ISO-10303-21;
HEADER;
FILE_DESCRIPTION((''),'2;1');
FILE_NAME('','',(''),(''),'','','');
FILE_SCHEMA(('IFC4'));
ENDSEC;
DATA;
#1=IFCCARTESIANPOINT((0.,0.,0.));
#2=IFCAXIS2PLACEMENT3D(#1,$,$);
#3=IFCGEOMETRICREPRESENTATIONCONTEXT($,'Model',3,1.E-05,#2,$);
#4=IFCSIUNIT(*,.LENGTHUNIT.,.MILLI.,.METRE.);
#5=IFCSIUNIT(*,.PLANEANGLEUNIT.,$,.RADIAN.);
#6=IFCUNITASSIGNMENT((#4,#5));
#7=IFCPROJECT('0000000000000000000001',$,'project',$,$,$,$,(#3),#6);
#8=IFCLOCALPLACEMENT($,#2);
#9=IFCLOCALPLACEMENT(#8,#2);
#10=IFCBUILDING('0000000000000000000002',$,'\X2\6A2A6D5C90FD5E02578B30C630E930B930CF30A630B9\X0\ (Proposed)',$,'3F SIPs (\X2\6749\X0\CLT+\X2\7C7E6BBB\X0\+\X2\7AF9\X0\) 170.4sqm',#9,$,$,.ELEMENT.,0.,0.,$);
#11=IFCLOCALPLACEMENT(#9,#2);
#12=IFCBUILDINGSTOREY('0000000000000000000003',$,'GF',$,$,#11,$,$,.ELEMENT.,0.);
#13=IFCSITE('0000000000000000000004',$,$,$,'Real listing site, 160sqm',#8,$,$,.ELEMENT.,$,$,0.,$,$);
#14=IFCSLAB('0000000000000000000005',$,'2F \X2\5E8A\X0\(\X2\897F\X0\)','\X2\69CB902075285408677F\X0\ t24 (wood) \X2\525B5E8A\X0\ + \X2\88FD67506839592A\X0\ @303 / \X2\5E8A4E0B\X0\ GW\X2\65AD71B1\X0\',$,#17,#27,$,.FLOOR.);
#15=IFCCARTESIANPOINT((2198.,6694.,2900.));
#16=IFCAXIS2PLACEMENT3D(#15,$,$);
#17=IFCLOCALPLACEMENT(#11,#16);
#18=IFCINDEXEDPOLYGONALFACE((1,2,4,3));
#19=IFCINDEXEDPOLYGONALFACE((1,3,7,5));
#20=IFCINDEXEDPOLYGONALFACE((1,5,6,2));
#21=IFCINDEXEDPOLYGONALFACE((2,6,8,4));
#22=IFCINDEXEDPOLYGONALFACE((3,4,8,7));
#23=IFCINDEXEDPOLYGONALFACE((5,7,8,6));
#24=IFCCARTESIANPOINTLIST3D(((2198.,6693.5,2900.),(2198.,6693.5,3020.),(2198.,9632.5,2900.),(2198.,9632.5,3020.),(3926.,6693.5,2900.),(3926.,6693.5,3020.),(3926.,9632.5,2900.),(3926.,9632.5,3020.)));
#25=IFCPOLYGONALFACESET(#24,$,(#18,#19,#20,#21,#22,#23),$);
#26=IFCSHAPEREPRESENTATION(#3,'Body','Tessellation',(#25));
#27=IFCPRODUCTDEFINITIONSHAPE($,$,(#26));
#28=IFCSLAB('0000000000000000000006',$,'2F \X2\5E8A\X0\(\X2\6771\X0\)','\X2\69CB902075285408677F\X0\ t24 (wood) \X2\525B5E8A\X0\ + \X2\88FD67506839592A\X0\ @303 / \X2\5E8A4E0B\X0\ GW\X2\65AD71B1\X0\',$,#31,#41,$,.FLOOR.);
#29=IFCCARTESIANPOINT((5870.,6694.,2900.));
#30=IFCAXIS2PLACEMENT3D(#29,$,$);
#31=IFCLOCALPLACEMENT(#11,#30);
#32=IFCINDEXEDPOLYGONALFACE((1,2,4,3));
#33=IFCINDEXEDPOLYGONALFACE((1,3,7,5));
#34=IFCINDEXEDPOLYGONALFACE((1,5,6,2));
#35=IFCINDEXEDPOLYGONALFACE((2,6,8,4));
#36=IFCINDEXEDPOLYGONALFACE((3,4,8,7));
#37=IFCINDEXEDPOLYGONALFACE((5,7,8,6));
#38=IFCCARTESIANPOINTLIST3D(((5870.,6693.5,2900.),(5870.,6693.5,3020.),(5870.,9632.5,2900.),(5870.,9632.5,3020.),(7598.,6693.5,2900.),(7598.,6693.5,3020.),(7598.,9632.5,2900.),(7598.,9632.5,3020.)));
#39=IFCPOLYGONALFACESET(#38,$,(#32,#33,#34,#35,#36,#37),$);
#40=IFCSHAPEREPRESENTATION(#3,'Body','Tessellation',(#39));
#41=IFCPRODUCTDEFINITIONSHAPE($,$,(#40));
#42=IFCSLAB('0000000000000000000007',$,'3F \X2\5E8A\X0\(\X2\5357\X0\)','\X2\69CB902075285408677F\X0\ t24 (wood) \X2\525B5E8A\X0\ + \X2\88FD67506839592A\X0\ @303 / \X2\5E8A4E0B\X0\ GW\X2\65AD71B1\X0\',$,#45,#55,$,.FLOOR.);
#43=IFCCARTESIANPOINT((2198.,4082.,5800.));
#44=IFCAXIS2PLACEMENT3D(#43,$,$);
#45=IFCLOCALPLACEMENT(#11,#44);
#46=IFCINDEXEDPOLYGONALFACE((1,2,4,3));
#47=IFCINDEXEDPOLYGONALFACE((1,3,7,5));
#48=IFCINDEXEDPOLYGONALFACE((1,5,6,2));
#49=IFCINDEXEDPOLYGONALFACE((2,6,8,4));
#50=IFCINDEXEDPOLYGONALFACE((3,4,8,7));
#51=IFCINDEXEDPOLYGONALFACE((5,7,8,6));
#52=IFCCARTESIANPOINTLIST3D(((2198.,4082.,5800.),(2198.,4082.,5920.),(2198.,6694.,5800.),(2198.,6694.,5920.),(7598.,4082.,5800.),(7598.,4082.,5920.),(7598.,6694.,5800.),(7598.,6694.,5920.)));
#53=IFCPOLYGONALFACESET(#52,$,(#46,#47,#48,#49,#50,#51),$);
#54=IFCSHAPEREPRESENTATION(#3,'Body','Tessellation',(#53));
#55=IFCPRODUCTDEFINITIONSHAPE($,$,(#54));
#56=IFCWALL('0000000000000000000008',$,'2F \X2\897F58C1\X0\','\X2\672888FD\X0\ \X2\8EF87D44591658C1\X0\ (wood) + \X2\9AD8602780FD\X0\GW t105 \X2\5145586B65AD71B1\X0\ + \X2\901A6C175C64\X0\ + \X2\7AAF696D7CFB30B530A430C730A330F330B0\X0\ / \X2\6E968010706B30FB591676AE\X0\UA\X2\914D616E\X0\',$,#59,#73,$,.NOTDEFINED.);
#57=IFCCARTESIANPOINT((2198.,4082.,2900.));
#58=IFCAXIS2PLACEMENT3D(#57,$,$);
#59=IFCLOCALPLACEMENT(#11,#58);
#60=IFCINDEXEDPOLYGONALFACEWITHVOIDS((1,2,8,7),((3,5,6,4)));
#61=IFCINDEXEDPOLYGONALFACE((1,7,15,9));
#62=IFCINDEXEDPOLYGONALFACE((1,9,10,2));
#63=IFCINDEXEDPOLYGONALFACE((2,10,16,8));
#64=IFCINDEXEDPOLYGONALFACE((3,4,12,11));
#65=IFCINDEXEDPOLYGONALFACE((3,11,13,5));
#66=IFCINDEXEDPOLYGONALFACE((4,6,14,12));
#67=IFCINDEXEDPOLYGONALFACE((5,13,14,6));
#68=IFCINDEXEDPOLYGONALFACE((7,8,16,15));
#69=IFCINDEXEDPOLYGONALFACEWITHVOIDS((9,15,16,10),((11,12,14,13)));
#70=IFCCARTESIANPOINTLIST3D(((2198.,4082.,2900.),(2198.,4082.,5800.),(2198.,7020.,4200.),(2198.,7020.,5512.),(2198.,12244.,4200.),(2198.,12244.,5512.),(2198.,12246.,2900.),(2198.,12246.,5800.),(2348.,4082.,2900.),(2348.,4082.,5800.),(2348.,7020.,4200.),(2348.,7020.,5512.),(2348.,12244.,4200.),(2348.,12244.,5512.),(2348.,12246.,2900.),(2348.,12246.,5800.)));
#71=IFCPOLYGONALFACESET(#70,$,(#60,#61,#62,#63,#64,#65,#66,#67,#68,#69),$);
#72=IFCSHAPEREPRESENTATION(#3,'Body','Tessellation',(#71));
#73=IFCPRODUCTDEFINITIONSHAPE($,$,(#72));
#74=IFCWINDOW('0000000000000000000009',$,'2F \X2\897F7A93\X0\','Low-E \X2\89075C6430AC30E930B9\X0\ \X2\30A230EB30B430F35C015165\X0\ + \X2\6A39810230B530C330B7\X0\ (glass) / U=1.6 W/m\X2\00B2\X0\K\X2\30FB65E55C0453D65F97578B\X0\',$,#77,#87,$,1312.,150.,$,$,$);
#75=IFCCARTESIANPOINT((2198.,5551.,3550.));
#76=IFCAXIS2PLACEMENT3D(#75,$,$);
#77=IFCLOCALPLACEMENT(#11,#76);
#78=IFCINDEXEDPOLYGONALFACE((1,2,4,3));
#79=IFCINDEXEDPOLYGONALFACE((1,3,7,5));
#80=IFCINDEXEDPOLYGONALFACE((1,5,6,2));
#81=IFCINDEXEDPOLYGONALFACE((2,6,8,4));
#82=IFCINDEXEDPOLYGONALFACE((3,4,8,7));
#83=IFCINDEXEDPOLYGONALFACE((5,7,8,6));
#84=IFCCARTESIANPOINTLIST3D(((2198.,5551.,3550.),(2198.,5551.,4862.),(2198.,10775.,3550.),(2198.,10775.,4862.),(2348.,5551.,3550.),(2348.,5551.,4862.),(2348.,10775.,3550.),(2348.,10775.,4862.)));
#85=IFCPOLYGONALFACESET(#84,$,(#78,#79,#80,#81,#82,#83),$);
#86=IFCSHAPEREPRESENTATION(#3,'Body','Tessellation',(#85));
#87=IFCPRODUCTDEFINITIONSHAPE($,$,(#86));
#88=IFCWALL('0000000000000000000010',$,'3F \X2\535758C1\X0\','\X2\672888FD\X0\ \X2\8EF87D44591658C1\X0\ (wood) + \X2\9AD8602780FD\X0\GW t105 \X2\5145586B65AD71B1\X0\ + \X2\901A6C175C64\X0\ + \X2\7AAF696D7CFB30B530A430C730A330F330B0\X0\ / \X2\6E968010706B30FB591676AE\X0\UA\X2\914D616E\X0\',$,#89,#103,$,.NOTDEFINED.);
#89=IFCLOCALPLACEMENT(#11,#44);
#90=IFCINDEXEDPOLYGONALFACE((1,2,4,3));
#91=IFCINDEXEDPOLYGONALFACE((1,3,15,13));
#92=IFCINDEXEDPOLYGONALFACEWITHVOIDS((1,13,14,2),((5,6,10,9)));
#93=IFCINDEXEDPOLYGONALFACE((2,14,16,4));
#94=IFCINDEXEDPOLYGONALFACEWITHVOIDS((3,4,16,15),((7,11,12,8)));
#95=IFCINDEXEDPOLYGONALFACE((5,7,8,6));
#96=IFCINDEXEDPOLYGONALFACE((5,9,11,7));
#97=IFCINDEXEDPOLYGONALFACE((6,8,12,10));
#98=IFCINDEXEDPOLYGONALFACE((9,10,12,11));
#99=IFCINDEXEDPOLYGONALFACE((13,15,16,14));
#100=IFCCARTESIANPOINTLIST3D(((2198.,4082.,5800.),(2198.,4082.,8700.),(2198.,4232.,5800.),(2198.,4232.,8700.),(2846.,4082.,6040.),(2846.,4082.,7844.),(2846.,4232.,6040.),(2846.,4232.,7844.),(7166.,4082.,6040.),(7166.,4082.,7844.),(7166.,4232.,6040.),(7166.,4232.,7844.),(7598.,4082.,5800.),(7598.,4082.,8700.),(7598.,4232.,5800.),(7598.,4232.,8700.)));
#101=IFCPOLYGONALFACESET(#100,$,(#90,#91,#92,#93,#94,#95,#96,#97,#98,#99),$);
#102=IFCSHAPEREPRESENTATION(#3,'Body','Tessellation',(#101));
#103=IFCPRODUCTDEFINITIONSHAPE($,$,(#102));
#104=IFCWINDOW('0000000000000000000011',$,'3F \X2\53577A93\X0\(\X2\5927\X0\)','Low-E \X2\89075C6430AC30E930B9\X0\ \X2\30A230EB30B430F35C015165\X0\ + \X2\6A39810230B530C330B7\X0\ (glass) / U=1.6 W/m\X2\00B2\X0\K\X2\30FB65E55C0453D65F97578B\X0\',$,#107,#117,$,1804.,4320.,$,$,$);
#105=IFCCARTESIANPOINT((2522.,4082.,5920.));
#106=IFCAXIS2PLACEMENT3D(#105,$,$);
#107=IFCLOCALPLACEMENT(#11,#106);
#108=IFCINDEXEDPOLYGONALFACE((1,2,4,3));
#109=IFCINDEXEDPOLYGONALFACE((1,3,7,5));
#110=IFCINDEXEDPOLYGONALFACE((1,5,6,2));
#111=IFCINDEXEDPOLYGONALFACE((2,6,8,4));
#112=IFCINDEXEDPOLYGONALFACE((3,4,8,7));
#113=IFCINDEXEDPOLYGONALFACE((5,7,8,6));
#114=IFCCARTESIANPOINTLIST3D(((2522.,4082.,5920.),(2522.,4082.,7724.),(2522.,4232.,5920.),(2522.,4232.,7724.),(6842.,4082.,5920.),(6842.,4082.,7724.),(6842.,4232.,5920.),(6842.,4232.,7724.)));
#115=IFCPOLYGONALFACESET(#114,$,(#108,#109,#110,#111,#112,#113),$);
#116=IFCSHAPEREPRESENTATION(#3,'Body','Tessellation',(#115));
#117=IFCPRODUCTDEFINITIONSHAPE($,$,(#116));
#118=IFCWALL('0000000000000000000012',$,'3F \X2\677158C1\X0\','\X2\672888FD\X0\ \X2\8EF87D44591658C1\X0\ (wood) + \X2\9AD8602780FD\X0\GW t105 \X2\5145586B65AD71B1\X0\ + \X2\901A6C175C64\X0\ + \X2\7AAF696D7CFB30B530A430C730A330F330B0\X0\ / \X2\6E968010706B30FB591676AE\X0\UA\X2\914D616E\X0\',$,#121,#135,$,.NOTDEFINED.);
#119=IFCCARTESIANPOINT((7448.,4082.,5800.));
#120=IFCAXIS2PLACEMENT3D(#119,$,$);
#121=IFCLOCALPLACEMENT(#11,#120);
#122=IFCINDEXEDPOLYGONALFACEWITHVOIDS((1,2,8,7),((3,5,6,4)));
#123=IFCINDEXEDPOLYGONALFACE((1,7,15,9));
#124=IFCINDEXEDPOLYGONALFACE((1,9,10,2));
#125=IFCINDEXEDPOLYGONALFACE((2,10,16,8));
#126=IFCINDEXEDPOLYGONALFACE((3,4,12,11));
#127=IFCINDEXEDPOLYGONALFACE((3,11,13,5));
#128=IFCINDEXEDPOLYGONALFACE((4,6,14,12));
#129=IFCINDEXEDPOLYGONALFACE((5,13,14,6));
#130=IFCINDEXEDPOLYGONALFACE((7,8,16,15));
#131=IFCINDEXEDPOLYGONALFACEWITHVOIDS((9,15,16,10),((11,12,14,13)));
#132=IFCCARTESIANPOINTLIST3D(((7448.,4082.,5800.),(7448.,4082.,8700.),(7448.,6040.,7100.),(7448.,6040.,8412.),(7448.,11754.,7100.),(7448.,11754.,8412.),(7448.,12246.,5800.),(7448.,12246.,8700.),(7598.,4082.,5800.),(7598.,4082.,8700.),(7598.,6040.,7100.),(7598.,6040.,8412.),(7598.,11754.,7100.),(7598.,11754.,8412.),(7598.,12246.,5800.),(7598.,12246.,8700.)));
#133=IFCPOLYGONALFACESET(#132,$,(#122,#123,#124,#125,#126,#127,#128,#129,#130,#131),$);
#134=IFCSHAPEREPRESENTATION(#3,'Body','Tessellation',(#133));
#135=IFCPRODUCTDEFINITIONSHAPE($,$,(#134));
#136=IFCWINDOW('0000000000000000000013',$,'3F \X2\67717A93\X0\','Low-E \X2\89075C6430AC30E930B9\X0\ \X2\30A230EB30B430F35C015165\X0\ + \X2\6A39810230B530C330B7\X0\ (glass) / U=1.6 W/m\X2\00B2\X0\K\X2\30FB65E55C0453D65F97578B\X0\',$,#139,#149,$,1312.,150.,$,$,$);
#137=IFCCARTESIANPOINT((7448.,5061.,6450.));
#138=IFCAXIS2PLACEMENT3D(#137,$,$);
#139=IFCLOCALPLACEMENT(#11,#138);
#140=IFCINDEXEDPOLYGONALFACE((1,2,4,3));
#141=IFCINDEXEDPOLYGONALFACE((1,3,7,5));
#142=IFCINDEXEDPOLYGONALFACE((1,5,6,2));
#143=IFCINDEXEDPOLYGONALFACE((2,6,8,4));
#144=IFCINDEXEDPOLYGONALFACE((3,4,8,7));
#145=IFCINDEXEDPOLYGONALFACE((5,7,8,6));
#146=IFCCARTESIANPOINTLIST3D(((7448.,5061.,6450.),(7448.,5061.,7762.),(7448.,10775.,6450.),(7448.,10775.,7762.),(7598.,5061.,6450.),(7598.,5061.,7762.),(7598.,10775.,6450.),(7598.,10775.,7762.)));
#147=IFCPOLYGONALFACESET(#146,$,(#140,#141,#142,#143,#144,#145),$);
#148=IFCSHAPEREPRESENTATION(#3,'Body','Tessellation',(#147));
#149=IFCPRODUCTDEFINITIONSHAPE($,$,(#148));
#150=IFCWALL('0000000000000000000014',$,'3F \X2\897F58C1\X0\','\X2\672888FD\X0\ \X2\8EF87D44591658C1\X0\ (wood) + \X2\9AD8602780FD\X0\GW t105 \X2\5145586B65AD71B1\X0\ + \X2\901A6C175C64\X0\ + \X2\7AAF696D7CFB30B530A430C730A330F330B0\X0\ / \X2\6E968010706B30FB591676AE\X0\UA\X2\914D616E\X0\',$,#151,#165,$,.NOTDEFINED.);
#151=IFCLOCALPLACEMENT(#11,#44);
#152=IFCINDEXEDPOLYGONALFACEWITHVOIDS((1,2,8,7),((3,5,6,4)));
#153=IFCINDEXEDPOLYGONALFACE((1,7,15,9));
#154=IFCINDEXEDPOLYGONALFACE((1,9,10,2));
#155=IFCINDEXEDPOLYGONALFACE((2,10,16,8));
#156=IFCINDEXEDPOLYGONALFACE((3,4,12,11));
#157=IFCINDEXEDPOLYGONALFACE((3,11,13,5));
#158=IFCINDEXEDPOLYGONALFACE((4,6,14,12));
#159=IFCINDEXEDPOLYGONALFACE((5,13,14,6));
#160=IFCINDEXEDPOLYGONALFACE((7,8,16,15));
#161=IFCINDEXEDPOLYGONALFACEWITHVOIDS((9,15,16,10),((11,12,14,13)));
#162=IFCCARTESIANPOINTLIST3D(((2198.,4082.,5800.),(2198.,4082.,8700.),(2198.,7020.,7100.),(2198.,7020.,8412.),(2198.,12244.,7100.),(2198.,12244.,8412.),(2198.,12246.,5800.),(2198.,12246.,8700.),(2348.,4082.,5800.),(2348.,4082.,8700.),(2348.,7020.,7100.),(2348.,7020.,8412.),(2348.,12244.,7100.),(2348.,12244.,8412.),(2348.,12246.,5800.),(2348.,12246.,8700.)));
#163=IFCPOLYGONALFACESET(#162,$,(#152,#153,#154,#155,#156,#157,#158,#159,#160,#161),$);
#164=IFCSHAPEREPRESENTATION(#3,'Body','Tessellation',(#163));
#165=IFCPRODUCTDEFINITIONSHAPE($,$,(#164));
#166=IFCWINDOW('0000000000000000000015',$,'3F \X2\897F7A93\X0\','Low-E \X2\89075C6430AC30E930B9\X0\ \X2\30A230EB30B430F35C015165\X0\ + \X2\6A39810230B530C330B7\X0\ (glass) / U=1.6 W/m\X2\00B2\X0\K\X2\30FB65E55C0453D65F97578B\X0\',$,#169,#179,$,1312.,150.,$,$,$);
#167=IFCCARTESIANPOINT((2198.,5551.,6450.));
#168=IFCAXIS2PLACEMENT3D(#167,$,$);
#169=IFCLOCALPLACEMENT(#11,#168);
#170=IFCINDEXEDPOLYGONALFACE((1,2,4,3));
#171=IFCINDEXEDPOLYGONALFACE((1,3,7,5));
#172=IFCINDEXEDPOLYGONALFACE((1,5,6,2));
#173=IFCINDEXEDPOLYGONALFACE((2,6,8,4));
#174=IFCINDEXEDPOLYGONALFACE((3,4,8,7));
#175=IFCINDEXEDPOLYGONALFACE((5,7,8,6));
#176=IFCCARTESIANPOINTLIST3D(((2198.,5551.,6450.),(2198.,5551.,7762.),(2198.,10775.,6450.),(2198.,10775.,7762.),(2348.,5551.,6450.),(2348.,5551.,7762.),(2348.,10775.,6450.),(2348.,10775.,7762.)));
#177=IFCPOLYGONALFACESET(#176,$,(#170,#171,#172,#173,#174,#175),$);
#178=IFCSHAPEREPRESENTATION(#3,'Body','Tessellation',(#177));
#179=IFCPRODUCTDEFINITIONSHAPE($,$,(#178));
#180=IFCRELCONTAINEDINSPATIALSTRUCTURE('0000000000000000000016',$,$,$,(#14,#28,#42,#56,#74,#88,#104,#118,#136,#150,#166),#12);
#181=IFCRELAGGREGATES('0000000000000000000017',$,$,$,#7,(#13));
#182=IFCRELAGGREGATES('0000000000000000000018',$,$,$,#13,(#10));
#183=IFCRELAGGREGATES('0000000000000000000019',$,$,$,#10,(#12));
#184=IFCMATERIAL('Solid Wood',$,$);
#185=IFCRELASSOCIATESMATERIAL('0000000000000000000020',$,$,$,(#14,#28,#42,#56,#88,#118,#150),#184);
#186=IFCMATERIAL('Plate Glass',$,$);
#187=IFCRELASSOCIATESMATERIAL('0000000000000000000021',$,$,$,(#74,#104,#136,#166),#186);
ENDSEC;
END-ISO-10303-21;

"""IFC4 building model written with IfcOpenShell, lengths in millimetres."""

from ifc_helpers import new_model, si_unit, frame, frame_2d, origin, place, context, project, spatial, rectangle, extrude, material, element, fill, save


model = new_model("IFC4")

# Units and contexts
model_context = context("Model", 3, precision=1e-05, world=origin())
ifc_project = project(units=[si_unit("LENGTHUNIT", "METRE", prefix="MILLI"), si_unit("PLANEANGLEUNIT", "RADIAN")], contexts=[model_context])

# Site, building, storey
site_placement = place(None, origin())
site = spatial("IfcSite", under=ifc_project, at=site_placement, ObjectType="Real listing site, 160sqm", CompositionType="ELEMENT", RefElevation=0.0)
building_placement = place(site_placement, origin())
building = spatial("IfcBuilding", under=site, at=building_placement, Name="横浜都市型テラスハウス (Proposed)", ObjectType="3F SIPs (杉CLT+籾殻+竹) 170.4sqm", CompositionType="ELEMENT", ElevationOfRefHeight=0.0, ElevationOfTerrain=0.0)
storey_placement = place(building_placement, origin())
storey = spatial("IfcBuildingStorey", under=building, at=storey_placement, Name="GF", CompositionType="ELEMENT", Elevation=0.0)

# Slabs
ifc_material_1 = material(Name="Solid Wood")
slab_1_placement = place(storey_placement, frame((2198.0, 6694.0, 2900.0)))
element("IfcSlab", 1, at=slab_1_placement, inside=storey, material=ifc_material_1, Name="2F 床(西)", Description="構造用合板 t24 (wood) 剛床 + 製材根太 @303 / 床下 GW断熱", PredefinedType="FLOOR", context=model_context, shape_type="SweptSolid", body=[
    extrude(rectangle(XDim=1728.0, YDim=2939.0, at=frame_2d((864.0, 1469.0))), frame((2198.0, 6694.0, 2900.0)), (0.0, 0.0, 1.0), 120.0),
])
slab_2_placement = place(storey_placement, frame((5870.0, 6694.0, 2900.0)))
element("IfcSlab", 2, at=slab_2_placement, inside=storey, material=ifc_material_1, Name="2F 床(東)", Description="構造用合板 t24 (wood) 剛床 + 製材根太 @303 / 床下 GW断熱", PredefinedType="FLOOR", context=model_context, shape_type="SweptSolid", body=[
    extrude(rectangle(XDim=1728.0, YDim=2939.0, at=frame_2d((864.0, 1469.0))), frame((5870.0, 6694.0, 2900.0)), (0.0, 0.0, 1.0), 120.0),
])
slab_3_placement = place(storey_placement, frame((2198.0, 4082.0, 5800.0)))
element("IfcSlab", 3, at=slab_3_placement, inside=storey, material=ifc_material_1, Name="3F 床(南)", Description="構造用合板 t24 (wood) 剛床 + 製材根太 @303 / 床下 GW断熱", PredefinedType="FLOOR", context=model_context, shape_type="SweptSolid", body=[
    extrude(rectangle(XDim=5400.0, YDim=2612.0, at=frame_2d((2700.0, 1306.0))), frame((2198.0, 4082.0, 5800.0)), (0.0, 0.0, 1.0), 120.0),
])

# Walls, openings, windows
wall_1_placement = place(storey_placement, frame((2198.0, 4082.0, 2900.0)))
wall_1 = element("IfcWall", 4, at=wall_1_placement, inside=storey, material=ifc_material_1, Name="2F 西壁", Description="木製 軸組外壁 (wood) + 高性能GW t105 充填断熱 + 通気層 + 窯業系サイディング / 準耐火・外皮UA配慮", PredefinedType="NOTDEFINED", context=model_context, shape_type="SweptSolid", body=[
    extrude(rectangle(XDim=150.0, YDim=8164.0, at=frame_2d((75.0, 4082.0))), frame((2198.0, 4082.0, 2900.0)), (0.0, 0.0, 1.0), 2900.0),
])
opening_1_placement = place(storey_placement, frame((2198.0, 5551.0, 3550.0)))
opening_1 = element("IfcOpeningElement", 5, at=opening_1_placement, cuts=wall_1, PredefinedType="NOTDEFINED", context=model_context, shape_type="SweptSolid", body=[
    extrude(rectangle(XDim=150.0, YDim=5224.0, at=frame_2d((75.0, 2612.0))), frame((2198.0, 5551.0, 3550.0)), (0.0, 0.0, 1.0), 1312.0),
])
ifc_material_2 = material(Name="Plate Glass")
window_1_placement = place(storey_placement, frame((2198.0, 5551.0, 3550.0)))
window_1 = element("IfcWindow", 6, at=window_1_placement, inside=storey, material=ifc_material_2, Name="2F 西窓", Description="Low-E 複層ガラス アルゴン封入 + 樹脂サッシ (glass) / U=1.6 W/m²K・日射取得型", OverallHeight=1312.0, OverallWidth=150.0, context=model_context, shape_type="SweptSolid", body=[
    extrude(rectangle(XDim=150.0, YDim=5224.0, at=frame_2d((75.0, 2612.0))), frame((2198.0, 5551.0, 3550.0)), (0.0, 0.0, 1.0), 1312.0),
])
fill(opening_1, window_1)
wall_2_placement = place(storey_placement, frame((2198.0, 4082.0, 5800.0)))
wall_2 = element("IfcWall", 7, at=wall_2_placement, inside=storey, material=ifc_material_1, Name="3F 南壁", Description="木製 軸組外壁 (wood) + 高性能GW t105 充填断熱 + 通気層 + 窯業系サイディング / 準耐火・外皮UA配慮", PredefinedType="NOTDEFINED", context=model_context, shape_type="SweptSolid", body=[
    extrude(rectangle(XDim=5400.0, YDim=150.0, at=frame_2d((2700.0, 75.0))), frame((2198.0, 4082.0, 5800.0)), (0.0, 0.0, 1.0), 2900.0),
])
opening_2_placement = place(storey_placement, frame((2522.0, 4082.0, 5920.0)))
opening_2 = element("IfcOpeningElement", 8, at=opening_2_placement, cuts=wall_2, PredefinedType="NOTDEFINED", context=model_context, shape_type="SweptSolid", body=[
    extrude(rectangle(XDim=4320.0, YDim=150.0, at=frame_2d((2160.0, 75.0))), frame((2522.0, 4082.0, 5920.0)), (0.0, 0.0, 1.0), 1804.0),
])
window_2_placement = place(storey_placement, frame((2522.0, 4082.0, 5920.0)))
window_2 = element("IfcWindow", 9, at=window_2_placement, inside=storey, material=ifc_material_2, Name="3F 南窓(大)", Description="Low-E 複層ガラス アルゴン封入 + 樹脂サッシ (glass) / U=1.6 W/m²K・日射取得型", OverallHeight=1804.0, OverallWidth=4320.0, context=model_context, shape_type="SweptSolid", body=[
    extrude(rectangle(XDim=4320.0, YDim=150.0, at=frame_2d((2160.0, 75.0))), frame((2522.0, 4082.0, 5920.0)), (0.0, 0.0, 1.0), 1804.0),
])
fill(opening_2, window_2)
wall_3_placement = place(storey_placement, frame((7448.0, 4082.0, 5800.0)))
wall_3 = element("IfcWall", 10, at=wall_3_placement, inside=storey, material=ifc_material_1, Name="3F 東壁", Description="木製 軸組外壁 (wood) + 高性能GW t105 充填断熱 + 通気層 + 窯業系サイディング / 準耐火・外皮UA配慮", PredefinedType="NOTDEFINED", context=model_context, shape_type="SweptSolid", body=[
    extrude(rectangle(XDim=150.0, YDim=8164.0, at=frame_2d((75.0, 4082.0))), frame((7448.0, 4082.0, 5800.0)), (0.0, 0.0, 1.0), 2900.0),
])
opening_3_placement = place(storey_placement, frame((7448.0, 5061.0, 6450.0)))
opening_3 = element("IfcOpeningElement", 11, at=opening_3_placement, cuts=wall_3, PredefinedType="NOTDEFINED", context=model_context, shape_type="SweptSolid", body=[
    extrude(rectangle(XDim=150.0, YDim=5714.0, at=frame_2d((75.0, 2857.0))), frame((7448.0, 5061.0, 6450.0)), (0.0, 0.0, 1.0), 1312.0),
])
window_3_placement = place(storey_placement, frame((7448.0, 5061.0, 6450.0)))
window_3 = element("IfcWindow", 12, at=window_3_placement, inside=storey, material=ifc_material_2, Name="3F 東窓", Description="Low-E 複層ガラス アルゴン封入 + 樹脂サッシ (glass) / U=1.6 W/m²K・日射取得型", OverallHeight=1312.0, OverallWidth=150.0, context=model_context, shape_type="SweptSolid", body=[
    extrude(rectangle(XDim=150.0, YDim=5714.0, at=frame_2d((75.0, 2857.0))), frame((7448.0, 5061.0, 6450.0)), (0.0, 0.0, 1.0), 1312.0),
])
fill(opening_3, window_3)
wall_4_placement = place(storey_placement, frame((2198.0, 4082.0, 5800.0)))
wall_4 = element("IfcWall", 13, at=wall_4_placement, inside=storey, material=ifc_material_1, Name="3F 西壁", Description="木製 軸組外壁 (wood) + 高性能GW t105 充填断熱 + 通気層 + 窯業系サイディング / 準耐火・外皮UA配慮", PredefinedType="NOTDEFINED", context=model_context, shape_type="SweptSolid", body=[
    extrude(rectangle(XDim=150.0, YDim=8164.0, at=frame_2d((75.0, 4082.0))), frame((2198.0, 4082.0, 5800.0)), (0.0, 0.0, 1.0), 2900.0),
])
opening_4_placement = place(storey_placement, frame((2198.0, 5551.0, 6450.0)))
opening_4 = element("IfcOpeningElement", 14, at=opening_4_placement, cuts=wall_4, PredefinedType="NOTDEFINED", context=model_context, shape_type="SweptSolid", body=[
    extrude(rectangle(XDim=150.0, YDim=5224.0, at=frame_2d((75.0, 2612.0))), frame((2198.0, 5551.0, 6450.0)), (0.0, 0.0, 1.0), 1312.0),
])
window_4_placement = place(storey_placement, frame((2198.0, 5551.0, 6450.0)))
window_4 = element("IfcWindow", 15, at=window_4_placement, inside=storey, material=ifc_material_2, Name="3F 西窓", Description="Low-E 複層ガラス アルゴン封入 + 樹脂サッシ (glass) / U=1.6 W/m²K・日射取得型", OverallHeight=1312.0, OverallWidth=150.0, context=model_context, shape_type="SweptSolid", body=[
    extrude(rectangle(XDim=150.0, YDim=5224.0, at=frame_2d((75.0, 2612.0))), frame((2198.0, 5551.0, 6450.0)), (0.0, 0.0, 1.0), 1312.0),
])
fill(opening_4, window_4)

save(model, "model.ifc")
